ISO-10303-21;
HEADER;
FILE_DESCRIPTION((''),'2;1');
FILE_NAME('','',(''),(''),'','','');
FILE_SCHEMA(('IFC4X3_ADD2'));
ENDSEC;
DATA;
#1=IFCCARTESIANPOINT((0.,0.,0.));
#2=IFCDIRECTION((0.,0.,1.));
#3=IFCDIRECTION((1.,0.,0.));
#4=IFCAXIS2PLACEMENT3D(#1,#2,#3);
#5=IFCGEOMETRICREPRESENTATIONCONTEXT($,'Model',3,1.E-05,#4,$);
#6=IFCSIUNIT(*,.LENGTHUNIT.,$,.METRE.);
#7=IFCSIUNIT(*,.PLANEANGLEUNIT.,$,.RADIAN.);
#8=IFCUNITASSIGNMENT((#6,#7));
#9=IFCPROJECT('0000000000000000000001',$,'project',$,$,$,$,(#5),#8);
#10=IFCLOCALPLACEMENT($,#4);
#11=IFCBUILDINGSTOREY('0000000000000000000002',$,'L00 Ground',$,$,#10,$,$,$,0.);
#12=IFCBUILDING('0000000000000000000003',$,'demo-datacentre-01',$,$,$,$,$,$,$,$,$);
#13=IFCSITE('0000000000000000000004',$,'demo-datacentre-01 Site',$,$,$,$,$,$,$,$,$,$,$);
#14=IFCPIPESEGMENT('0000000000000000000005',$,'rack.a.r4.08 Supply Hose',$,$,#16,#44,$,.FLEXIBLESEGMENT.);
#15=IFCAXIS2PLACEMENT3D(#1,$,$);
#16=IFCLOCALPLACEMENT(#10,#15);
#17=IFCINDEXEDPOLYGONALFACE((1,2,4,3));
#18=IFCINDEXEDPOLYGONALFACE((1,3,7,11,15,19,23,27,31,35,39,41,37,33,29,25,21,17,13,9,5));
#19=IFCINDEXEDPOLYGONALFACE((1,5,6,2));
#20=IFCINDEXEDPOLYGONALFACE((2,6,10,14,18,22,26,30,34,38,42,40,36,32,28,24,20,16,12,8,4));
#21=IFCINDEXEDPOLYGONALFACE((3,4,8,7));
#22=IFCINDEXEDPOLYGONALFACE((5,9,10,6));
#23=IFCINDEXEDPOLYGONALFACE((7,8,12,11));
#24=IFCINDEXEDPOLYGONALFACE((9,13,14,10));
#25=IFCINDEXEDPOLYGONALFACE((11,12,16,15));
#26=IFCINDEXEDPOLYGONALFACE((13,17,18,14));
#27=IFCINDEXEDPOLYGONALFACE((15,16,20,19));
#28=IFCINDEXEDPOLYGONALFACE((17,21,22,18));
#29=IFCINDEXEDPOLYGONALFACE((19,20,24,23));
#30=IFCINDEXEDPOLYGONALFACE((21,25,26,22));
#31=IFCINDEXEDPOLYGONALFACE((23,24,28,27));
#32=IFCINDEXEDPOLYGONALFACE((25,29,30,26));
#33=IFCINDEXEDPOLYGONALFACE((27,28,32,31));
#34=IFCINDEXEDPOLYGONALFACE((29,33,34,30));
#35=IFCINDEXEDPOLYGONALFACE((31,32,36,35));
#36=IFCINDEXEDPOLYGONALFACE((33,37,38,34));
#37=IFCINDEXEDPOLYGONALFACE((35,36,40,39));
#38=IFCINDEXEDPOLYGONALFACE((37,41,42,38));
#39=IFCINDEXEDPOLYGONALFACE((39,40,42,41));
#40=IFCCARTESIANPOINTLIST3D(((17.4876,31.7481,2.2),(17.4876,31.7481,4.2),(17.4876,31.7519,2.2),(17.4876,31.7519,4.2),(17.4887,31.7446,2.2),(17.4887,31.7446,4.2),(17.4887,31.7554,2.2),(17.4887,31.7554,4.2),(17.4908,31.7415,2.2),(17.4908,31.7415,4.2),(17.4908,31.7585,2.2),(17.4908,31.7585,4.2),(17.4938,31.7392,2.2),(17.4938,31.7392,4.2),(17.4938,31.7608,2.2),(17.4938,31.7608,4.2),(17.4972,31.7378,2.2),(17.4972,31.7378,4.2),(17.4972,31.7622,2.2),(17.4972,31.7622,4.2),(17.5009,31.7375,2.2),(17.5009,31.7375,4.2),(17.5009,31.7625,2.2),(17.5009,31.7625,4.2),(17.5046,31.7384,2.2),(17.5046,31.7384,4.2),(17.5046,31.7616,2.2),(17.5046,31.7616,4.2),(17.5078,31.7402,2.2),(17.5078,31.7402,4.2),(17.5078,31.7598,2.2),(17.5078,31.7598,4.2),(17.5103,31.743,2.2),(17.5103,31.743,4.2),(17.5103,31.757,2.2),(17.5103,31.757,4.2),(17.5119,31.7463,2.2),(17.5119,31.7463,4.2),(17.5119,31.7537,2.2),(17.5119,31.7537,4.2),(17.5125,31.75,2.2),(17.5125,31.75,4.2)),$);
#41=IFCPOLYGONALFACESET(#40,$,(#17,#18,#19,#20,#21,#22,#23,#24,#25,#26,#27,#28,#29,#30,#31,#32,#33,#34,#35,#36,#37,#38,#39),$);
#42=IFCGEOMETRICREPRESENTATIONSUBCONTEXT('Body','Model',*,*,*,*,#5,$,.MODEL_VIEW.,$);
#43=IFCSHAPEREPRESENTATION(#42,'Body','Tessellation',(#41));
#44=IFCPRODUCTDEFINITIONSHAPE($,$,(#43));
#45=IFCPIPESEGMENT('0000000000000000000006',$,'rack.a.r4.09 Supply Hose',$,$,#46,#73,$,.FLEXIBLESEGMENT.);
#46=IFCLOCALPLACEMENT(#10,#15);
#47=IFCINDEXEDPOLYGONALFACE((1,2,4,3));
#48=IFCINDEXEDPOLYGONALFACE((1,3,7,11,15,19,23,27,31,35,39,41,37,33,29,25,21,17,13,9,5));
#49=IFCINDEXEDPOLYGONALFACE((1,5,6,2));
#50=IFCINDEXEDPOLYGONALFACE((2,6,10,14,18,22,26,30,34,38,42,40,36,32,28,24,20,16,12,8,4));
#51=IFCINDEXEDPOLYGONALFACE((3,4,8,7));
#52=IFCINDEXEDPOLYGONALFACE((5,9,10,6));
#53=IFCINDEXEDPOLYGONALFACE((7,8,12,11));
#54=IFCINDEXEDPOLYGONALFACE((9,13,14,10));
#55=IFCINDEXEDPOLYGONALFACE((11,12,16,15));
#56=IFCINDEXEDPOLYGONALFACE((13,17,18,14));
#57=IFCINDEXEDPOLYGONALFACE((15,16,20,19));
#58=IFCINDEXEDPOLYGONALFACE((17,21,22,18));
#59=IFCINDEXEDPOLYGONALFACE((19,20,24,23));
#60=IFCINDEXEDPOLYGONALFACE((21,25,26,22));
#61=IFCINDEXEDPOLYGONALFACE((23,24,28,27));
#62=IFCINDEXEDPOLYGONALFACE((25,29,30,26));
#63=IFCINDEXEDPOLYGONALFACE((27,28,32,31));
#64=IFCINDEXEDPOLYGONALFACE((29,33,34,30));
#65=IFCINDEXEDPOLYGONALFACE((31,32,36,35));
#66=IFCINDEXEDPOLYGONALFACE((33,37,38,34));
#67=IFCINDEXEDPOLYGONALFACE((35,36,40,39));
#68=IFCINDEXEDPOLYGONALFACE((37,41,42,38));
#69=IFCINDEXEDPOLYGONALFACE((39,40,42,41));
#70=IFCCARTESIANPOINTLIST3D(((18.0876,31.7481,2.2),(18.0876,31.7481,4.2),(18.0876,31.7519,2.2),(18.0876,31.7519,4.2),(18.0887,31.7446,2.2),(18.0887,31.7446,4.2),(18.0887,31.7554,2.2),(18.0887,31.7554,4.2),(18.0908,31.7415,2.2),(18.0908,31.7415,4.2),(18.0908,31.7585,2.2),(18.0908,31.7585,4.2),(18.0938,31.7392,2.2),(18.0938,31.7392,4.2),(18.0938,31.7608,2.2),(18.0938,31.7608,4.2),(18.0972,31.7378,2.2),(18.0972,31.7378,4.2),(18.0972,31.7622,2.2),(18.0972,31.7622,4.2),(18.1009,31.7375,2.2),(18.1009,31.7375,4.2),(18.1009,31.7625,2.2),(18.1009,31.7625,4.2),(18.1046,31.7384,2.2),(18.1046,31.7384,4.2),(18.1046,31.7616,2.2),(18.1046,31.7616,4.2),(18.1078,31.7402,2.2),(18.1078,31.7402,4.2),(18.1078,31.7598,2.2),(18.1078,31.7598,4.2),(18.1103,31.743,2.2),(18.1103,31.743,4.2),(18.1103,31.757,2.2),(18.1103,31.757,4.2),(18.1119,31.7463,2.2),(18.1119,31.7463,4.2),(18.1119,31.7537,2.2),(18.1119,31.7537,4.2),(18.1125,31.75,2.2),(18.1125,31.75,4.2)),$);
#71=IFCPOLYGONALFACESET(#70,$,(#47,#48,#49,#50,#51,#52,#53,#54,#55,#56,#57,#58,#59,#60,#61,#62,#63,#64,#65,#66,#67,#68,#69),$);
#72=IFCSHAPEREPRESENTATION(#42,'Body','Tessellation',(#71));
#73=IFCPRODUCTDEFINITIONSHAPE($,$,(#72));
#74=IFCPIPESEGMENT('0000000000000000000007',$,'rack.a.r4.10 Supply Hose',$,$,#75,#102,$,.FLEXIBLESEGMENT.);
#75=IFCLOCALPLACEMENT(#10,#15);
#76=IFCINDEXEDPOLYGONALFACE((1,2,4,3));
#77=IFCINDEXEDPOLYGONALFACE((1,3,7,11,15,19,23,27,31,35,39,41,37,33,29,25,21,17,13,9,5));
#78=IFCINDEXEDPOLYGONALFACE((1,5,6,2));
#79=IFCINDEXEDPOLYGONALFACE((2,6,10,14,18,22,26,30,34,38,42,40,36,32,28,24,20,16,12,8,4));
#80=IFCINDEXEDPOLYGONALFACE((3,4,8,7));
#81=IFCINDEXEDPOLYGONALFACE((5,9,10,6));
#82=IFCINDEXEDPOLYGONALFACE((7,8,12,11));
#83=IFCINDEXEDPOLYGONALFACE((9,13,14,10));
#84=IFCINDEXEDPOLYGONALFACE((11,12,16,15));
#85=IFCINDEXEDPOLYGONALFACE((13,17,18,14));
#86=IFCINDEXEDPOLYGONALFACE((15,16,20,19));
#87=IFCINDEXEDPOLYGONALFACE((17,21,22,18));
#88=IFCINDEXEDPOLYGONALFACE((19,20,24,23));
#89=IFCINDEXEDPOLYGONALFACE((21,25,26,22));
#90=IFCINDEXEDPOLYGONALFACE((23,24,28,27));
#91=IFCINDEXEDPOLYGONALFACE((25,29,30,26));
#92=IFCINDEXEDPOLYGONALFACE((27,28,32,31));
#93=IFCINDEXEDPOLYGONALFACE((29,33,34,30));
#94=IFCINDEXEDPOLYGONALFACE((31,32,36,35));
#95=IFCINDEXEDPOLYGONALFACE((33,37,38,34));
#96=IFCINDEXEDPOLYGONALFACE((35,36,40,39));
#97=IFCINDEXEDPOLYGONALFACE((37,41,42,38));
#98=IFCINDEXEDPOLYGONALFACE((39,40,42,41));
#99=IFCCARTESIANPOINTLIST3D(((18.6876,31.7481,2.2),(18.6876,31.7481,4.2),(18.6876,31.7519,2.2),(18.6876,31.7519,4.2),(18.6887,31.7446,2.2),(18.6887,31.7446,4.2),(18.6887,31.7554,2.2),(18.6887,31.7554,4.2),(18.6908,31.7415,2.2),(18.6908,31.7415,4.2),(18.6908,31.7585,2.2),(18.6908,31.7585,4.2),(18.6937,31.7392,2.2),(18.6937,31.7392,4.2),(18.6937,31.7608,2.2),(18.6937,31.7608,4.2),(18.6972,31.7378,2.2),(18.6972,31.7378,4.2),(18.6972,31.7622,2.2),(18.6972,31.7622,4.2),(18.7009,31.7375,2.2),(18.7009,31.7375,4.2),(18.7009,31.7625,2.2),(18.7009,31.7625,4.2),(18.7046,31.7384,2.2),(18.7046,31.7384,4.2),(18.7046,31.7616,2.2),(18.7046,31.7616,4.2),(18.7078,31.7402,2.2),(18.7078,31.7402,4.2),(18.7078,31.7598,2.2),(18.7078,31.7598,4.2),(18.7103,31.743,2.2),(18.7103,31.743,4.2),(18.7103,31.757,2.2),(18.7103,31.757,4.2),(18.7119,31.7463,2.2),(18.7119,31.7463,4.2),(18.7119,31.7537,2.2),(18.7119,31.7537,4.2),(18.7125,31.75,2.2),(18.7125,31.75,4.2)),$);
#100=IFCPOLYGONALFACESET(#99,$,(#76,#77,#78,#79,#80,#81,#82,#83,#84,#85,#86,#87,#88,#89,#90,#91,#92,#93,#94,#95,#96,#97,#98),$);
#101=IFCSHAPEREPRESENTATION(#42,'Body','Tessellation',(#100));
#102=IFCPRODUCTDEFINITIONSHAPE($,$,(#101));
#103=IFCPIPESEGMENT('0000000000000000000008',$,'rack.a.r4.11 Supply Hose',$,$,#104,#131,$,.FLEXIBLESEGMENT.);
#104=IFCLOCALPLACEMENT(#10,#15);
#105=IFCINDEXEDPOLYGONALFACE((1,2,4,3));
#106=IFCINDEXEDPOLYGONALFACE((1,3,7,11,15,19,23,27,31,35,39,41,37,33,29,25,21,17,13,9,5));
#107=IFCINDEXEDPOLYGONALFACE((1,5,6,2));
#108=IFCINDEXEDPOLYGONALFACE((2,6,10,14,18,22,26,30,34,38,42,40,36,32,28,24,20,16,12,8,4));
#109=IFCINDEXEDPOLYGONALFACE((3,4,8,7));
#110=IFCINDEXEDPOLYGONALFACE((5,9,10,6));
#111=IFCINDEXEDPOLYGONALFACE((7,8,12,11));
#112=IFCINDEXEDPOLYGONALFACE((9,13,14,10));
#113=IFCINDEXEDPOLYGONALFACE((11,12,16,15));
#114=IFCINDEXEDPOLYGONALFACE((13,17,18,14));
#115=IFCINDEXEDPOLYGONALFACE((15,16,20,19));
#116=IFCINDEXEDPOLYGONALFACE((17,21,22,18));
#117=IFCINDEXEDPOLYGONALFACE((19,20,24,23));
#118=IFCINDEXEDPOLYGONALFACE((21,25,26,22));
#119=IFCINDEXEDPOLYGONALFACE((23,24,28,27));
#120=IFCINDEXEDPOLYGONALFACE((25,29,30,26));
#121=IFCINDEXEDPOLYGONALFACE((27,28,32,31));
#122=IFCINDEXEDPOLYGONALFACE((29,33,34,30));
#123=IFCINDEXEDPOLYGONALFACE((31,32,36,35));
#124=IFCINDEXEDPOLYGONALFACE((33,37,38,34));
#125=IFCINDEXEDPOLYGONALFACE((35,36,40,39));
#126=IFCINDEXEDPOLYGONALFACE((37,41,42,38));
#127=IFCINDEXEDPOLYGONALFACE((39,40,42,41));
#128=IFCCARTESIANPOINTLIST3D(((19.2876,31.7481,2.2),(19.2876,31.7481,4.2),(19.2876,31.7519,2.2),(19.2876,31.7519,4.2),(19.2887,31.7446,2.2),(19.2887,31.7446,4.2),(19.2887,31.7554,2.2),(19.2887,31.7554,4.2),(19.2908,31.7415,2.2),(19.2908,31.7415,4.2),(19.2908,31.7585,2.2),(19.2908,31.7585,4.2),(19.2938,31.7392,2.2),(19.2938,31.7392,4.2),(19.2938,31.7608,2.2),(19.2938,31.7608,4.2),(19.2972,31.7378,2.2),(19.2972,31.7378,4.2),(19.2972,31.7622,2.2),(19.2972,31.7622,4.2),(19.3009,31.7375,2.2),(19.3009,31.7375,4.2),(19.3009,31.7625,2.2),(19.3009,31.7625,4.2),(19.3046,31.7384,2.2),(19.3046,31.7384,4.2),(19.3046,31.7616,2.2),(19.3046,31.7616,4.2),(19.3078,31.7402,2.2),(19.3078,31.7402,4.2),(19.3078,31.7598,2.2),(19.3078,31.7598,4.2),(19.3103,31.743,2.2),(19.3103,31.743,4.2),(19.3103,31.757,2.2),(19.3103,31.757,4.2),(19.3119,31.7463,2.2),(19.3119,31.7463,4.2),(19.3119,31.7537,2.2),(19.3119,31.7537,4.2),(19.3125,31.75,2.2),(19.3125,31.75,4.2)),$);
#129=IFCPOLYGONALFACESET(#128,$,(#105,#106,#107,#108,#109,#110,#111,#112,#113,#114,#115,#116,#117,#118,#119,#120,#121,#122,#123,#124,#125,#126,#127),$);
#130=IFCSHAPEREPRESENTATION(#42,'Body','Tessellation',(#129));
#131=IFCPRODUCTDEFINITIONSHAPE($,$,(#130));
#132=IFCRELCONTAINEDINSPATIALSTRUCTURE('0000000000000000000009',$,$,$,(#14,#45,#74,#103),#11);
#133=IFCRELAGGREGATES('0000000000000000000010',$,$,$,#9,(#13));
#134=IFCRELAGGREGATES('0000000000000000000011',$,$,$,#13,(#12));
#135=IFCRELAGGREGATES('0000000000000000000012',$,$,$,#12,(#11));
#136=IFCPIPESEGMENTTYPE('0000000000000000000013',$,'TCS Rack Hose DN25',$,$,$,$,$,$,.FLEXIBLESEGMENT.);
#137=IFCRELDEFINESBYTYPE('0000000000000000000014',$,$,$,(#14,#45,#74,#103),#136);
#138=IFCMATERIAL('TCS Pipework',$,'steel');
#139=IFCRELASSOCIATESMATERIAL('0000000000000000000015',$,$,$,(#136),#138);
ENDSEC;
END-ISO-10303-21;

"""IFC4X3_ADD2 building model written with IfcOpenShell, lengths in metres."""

from ifc_helpers import new_model, si_unit, frame, origin_with_axes, place, context, subcontext, project, spatial, circle, extrude, material, type_object, element, save


model = new_model("IFC4X3_ADD2")

# Units and contexts
model_context = context("Model", 3, precision=1e-05, world=origin_with_axes())
body_context = subcontext(model_context, "Body", "Model", "MODEL_VIEW")
ifc_project = project(units=[si_unit("LENGTHUNIT", "METRE"), si_unit("PLANEANGLEUNIT", "RADIAN")], contexts=[model_context])

# Site, building, storey
site = spatial("IfcSite", under=ifc_project, Name="demo-datacentre-01 Site")
building = spatial("IfcBuilding", under=site, Name="demo-datacentre-01")
storey_placement = place(None, origin_with_axes())
storey = spatial("IfcBuildingStorey", under=building, at=storey_placement, Name="L00 Ground", Elevation=0.0)

# Shared definitions
ifc_material = material(Name="TCS Pipework", Category="steel")

# Pipe segments
pipe_segment_type_1 = type_object("IfcPipeSegmentType", Name="TCS Rack Hose DN25", PredefinedType="FLEXIBLESEGMENT", material=ifc_material)
for number, where, z_axis, x_axis, name in (
    (1, (17.5, 31.75, 4.2), (0.0, 0.0, -1.0), (1.0, 0.0, 0.0), "rack.a.r4.08 Supply Hose"),
    (2, (18.1, 31.75, 4.2), (0.0, 0.0, -1.0), (1.0, 0.0, 0.0), "rack.a.r4.09 Supply Hose"),
    (3, (18.7, 31.75, 4.2), (0.0, 0.0, -1.0), (1.0, 0.0, 0.0), "rack.a.r4.10 Supply Hose"),
    (4, (19.3, 31.75, 4.2), (0.0, 0.0, -1.0), (1.0, 0.0, 0.0), "rack.a.r4.11 Supply Hose"),
):
    element("IfcPipeSegment", number, at=place(storey_placement, frame(where, z_axis=z_axis, x_axis=x_axis)), inside=storey, type_object=pipe_segment_type_1, Name=name, PredefinedType="FLEXIBLESEGMENT", context=body_context, shape_type="SweptSolid", body=[
        extrude(circle(Radius=0.0125), origin_with_axes(), (0.0, 0.0, 1.0), 2.0),
    ])

save(model, "model.ifc")
